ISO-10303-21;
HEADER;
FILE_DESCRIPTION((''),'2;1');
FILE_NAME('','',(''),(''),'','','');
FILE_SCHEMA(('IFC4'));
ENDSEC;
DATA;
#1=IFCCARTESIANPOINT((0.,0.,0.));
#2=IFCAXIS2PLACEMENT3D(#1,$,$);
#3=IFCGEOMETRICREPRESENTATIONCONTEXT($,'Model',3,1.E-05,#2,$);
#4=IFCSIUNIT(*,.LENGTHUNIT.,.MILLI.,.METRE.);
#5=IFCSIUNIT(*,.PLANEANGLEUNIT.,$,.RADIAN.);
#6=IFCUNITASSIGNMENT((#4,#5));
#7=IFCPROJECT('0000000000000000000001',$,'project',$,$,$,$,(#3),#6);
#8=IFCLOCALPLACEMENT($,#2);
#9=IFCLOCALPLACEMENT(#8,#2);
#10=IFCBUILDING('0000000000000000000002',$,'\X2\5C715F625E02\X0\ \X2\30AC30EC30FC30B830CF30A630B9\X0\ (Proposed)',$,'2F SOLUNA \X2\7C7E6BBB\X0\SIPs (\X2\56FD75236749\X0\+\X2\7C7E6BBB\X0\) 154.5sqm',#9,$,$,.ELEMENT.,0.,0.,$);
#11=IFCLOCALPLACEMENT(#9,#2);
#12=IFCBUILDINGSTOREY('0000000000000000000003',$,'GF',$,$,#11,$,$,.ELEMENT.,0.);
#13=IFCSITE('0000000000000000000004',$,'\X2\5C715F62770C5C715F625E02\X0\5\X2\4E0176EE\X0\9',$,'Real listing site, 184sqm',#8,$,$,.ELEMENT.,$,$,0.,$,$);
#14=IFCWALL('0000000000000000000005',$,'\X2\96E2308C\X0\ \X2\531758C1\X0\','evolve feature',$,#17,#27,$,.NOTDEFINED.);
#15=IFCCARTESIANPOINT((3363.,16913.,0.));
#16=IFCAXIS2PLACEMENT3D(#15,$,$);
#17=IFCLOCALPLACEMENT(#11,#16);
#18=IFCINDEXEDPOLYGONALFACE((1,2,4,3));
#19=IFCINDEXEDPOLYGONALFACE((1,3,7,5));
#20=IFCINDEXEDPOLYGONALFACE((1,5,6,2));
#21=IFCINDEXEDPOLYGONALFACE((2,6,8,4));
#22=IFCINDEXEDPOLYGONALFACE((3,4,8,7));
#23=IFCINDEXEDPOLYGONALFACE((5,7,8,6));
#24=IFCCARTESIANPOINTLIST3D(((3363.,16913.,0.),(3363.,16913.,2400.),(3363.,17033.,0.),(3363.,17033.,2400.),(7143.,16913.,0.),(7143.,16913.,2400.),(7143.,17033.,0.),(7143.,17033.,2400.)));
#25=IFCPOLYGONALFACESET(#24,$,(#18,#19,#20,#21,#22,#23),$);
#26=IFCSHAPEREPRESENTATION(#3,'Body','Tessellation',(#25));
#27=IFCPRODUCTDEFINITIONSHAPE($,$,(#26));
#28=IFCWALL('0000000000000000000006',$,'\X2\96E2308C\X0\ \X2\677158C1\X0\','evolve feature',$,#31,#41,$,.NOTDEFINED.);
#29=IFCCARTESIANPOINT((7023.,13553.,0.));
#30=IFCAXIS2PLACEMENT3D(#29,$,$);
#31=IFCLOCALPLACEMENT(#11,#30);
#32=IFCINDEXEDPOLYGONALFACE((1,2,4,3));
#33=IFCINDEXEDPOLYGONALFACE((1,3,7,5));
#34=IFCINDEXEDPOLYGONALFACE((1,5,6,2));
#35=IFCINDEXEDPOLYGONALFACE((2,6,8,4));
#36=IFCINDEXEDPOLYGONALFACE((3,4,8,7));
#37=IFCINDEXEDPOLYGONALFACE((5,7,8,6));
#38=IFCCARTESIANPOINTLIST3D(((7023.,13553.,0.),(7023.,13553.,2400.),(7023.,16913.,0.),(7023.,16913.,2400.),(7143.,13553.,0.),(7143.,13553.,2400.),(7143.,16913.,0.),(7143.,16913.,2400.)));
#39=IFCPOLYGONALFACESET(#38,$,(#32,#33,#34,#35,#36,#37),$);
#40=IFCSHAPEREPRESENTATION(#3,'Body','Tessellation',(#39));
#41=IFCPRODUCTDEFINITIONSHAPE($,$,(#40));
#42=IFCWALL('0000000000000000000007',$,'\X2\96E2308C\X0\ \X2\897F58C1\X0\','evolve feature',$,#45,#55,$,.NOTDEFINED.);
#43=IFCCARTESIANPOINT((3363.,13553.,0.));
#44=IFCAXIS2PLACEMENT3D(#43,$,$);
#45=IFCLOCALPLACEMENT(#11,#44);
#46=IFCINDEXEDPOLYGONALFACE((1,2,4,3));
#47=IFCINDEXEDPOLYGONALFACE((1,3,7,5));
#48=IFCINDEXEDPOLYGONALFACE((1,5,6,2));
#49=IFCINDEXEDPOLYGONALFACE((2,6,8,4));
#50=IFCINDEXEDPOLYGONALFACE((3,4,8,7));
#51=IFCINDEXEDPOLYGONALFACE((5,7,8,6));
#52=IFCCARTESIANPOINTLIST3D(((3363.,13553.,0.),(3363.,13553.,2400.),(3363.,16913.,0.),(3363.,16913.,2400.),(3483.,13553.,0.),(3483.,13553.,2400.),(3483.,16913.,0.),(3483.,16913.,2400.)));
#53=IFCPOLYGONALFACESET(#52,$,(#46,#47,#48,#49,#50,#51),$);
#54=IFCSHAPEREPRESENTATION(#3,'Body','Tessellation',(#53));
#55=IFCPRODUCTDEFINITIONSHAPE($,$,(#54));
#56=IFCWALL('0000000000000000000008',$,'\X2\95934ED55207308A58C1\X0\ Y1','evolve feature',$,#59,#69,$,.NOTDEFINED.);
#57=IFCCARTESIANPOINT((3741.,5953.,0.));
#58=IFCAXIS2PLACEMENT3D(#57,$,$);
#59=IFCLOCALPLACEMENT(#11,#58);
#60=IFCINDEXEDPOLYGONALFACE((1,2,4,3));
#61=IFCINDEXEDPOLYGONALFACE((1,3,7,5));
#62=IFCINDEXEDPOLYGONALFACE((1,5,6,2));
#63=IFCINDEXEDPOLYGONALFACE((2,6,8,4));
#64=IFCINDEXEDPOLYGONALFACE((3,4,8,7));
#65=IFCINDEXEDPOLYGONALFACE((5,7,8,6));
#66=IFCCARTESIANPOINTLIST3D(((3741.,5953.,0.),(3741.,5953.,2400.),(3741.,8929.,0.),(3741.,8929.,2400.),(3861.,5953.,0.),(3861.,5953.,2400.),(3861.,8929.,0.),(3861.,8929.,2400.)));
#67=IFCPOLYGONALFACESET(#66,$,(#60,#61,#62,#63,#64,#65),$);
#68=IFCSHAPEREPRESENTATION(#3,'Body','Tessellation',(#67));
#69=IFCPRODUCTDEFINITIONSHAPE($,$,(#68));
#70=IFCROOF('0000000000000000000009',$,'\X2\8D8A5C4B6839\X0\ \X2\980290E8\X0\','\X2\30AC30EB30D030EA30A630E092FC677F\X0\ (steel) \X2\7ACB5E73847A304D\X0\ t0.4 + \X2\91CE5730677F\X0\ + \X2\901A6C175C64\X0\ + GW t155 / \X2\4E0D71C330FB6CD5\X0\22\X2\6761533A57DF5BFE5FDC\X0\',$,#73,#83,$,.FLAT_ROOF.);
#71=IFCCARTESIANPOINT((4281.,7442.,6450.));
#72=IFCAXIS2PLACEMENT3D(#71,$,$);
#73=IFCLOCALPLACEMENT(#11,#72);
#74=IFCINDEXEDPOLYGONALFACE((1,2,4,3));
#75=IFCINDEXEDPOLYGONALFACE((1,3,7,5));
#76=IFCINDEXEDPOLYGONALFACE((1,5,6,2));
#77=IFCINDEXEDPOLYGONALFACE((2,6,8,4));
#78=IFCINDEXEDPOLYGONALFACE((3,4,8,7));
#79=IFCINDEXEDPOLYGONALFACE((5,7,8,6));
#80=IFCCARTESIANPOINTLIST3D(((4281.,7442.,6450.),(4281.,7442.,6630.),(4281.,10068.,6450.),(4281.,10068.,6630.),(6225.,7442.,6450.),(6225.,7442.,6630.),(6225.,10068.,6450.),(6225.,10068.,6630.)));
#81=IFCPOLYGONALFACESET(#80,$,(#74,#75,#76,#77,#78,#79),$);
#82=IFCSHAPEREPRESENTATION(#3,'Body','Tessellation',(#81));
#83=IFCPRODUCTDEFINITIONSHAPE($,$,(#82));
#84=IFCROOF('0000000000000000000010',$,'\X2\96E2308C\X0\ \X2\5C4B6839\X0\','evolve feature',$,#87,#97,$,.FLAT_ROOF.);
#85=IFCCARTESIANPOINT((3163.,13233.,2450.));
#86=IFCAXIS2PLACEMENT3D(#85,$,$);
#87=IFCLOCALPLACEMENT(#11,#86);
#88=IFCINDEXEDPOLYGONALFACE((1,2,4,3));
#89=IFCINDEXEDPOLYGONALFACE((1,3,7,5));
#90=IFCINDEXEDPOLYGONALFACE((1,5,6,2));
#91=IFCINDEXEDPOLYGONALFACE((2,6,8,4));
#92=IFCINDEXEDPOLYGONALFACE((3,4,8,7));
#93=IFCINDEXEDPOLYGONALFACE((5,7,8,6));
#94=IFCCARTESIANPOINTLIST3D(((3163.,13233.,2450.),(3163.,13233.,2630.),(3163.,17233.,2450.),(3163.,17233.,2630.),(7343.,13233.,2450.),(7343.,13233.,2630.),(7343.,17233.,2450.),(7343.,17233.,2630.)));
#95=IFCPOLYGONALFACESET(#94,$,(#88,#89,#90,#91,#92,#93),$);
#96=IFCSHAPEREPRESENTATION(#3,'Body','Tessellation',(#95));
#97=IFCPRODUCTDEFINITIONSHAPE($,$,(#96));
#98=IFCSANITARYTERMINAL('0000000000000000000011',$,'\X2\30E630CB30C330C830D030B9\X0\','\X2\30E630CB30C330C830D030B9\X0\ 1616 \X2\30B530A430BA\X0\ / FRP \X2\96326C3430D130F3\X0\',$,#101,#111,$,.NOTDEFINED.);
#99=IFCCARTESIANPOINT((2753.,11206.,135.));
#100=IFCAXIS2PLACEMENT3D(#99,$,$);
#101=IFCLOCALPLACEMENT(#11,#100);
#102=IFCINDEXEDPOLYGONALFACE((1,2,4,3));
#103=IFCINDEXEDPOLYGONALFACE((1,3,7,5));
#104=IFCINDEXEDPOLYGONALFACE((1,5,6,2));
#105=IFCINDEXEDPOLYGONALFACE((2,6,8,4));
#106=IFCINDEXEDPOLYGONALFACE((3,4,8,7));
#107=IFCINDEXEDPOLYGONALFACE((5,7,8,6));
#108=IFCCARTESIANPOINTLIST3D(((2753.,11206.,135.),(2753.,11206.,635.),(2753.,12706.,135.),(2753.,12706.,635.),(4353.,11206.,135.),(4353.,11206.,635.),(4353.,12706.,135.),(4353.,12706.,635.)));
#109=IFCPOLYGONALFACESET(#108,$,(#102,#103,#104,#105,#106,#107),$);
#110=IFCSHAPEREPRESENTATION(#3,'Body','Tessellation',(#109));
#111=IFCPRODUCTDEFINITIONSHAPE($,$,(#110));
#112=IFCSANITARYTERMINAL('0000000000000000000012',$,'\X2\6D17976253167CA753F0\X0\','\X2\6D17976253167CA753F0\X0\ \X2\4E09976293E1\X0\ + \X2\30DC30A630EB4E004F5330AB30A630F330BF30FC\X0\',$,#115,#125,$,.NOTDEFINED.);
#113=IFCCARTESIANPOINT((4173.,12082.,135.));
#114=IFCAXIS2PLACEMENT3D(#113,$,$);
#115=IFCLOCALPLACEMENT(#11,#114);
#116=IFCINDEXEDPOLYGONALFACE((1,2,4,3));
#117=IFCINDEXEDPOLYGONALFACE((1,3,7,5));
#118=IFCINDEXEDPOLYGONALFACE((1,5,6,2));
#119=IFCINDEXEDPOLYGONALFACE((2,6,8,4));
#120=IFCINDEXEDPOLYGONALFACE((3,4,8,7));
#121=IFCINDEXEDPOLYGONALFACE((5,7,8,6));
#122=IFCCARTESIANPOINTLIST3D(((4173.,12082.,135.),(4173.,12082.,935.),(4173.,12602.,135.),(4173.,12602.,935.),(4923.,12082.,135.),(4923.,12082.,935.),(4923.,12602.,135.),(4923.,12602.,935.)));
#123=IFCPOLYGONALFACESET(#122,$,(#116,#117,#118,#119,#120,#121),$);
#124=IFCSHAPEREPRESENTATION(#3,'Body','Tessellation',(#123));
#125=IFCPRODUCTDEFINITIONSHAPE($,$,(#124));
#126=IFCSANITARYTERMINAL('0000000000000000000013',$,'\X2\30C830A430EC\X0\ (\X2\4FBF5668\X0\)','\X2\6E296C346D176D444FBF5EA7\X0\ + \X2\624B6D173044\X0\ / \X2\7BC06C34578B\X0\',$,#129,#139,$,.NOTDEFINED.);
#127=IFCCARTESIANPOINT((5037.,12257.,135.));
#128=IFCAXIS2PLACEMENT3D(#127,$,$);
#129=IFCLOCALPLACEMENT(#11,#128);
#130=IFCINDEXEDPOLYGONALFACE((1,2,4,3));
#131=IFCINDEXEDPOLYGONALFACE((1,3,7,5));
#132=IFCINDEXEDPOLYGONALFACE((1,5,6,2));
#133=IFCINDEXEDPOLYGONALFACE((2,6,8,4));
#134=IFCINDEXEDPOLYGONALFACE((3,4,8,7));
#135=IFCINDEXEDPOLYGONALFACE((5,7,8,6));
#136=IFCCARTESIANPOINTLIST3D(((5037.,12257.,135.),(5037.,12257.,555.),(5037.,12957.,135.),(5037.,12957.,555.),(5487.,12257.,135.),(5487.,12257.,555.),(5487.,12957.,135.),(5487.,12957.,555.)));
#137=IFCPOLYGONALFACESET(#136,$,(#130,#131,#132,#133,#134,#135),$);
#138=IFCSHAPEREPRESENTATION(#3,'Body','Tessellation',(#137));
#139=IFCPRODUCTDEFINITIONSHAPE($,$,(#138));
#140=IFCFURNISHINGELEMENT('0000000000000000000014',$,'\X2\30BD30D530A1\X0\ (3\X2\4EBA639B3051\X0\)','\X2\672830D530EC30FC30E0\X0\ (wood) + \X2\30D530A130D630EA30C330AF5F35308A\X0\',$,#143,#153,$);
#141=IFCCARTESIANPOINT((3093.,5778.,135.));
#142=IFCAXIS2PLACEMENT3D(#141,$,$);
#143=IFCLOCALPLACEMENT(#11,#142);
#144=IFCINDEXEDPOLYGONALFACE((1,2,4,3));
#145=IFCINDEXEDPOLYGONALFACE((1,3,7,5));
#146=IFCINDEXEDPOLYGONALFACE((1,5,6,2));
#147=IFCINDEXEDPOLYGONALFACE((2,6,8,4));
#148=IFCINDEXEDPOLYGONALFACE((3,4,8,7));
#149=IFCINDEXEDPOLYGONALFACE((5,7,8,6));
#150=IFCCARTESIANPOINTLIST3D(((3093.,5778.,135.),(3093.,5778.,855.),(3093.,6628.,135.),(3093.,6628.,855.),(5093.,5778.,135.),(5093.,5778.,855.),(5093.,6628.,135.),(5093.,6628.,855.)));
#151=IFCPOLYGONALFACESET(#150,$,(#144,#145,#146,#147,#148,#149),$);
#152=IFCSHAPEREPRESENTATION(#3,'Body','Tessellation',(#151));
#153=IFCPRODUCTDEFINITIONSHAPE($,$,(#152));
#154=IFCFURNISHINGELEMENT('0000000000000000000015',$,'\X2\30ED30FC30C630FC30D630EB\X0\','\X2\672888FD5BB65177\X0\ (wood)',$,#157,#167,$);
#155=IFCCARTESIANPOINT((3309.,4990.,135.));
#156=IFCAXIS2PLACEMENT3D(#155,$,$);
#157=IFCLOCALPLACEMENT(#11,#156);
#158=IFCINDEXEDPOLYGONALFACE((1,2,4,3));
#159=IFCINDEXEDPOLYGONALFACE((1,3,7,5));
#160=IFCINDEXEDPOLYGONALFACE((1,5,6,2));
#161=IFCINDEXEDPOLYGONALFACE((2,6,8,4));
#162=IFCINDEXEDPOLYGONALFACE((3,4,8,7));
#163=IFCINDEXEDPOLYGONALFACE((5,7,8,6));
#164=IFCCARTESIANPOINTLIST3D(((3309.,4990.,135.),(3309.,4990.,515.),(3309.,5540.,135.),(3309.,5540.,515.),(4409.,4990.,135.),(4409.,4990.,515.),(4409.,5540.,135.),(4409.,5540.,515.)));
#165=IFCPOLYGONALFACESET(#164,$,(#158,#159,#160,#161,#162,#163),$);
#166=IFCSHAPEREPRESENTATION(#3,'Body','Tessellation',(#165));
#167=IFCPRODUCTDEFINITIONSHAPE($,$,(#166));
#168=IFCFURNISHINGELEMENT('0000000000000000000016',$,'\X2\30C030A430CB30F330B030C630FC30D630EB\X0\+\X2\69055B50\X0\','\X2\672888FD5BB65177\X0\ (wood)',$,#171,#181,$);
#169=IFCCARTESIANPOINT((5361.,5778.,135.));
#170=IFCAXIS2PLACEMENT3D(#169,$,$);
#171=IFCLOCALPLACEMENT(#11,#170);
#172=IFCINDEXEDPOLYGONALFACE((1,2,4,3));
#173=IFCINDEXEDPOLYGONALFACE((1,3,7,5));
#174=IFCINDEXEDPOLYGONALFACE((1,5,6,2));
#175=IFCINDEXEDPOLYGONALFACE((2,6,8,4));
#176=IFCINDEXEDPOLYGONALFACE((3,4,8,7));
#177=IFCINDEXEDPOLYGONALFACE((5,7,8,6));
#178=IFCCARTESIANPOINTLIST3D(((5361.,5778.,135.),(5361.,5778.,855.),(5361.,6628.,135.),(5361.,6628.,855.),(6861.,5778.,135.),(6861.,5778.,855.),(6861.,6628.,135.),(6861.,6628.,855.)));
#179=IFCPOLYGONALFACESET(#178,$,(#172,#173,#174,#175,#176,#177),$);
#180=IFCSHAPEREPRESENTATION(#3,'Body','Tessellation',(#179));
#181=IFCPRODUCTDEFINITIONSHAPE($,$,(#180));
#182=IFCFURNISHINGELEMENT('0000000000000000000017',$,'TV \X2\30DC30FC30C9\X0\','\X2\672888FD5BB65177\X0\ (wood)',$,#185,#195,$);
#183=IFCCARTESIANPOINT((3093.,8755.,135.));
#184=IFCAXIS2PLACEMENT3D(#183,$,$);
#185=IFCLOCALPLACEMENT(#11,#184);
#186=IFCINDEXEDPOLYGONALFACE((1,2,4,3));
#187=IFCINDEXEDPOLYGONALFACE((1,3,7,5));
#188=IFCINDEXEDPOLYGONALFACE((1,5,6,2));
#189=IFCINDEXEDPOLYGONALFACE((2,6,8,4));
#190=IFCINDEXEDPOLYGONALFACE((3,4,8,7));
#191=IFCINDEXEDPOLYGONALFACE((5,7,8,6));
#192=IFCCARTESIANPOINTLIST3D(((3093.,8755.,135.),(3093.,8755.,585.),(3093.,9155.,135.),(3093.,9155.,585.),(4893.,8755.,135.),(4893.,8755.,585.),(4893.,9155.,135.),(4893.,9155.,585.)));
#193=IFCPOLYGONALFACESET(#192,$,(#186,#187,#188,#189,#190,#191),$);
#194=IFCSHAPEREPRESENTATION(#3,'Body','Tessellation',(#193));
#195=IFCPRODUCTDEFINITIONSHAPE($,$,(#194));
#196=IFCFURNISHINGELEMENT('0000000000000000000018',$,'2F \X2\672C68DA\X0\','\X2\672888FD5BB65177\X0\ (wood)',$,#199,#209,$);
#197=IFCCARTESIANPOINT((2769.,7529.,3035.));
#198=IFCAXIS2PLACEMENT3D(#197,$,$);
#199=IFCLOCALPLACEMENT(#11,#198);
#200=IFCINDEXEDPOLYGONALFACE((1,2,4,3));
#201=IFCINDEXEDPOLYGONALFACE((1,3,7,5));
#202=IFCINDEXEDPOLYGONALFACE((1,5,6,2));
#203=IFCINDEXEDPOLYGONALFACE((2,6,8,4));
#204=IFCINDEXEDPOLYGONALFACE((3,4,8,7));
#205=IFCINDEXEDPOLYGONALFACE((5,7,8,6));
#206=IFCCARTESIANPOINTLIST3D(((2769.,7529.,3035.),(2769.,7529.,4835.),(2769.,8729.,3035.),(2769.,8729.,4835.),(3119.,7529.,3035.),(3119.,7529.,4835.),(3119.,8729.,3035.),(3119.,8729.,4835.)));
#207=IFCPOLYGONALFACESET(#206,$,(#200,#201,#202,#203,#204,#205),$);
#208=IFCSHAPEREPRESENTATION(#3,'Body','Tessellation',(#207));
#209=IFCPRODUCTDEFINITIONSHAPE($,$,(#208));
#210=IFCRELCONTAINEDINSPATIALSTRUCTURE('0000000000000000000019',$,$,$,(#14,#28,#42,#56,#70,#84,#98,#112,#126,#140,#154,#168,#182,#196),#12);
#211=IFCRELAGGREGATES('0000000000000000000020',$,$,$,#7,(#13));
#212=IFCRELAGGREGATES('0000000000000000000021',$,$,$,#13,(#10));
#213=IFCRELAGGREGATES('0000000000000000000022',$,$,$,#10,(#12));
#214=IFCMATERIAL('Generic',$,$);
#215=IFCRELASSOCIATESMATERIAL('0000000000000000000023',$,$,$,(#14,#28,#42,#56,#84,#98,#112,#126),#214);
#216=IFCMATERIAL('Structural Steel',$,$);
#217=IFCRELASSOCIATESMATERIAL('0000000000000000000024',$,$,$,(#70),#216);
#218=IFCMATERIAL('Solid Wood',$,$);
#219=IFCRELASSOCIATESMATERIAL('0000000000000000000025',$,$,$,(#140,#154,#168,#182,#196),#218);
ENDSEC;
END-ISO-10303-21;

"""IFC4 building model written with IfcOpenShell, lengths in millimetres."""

from ifc_helpers import new_model, si_unit, frame, frame_2d, origin, place, context, project, spatial, rectangle, extrude, material, element, save


model = new_model("IFC4")

# Units and contexts
model_context = context("Model", 3, precision=1e-05, world=origin())
ifc_project = project(units=[si_unit("LENGTHUNIT", "METRE", prefix="MILLI"), si_unit("PLANEANGLEUNIT", "RADIAN")], contexts=[model_context])

# Site, building, storey
site_placement = place(None, origin())
site = spatial("IfcSite", under=ifc_project, at=site_placement, Name="山形県山形市5丁目9", ObjectType="Real listing site, 184sqm", CompositionType="ELEMENT", RefElevation=0.0)
building_placement = place(site_placement, origin())
building = spatial("IfcBuilding", under=site, at=building_placement, Name="山形市 ガレージハウス (Proposed)", ObjectType="2F SOLUNA 籾殻SIPs (国産杉+籾殻) 154.5sqm", CompositionType="ELEMENT", ElevationOfRefHeight=0.0, ElevationOfTerrain=0.0)
storey_placement = place(building_placement, origin())
storey = spatial("IfcBuildingStorey", under=building, at=storey_placement, Name="GF", CompositionType="ELEMENT", Elevation=0.0)

# Shared definitions
ifc_material_1 = material(Name="Generic")

# Shared definitions
ifc_material_2 = material(Name="Solid Wood")

# Walls
wall_1_placement = place(storey_placement, frame((3363.0, 16913.0, 0.0)))
element("IfcWall", 1, at=wall_1_placement, inside=storey, material=ifc_material_1, Name="離れ 北壁", Description="evolve feature", PredefinedType="NOTDEFINED", context=model_context, shape_type="SweptSolid", body=[
    extrude(rectangle(XDim=3780.0, YDim=120.0, at=frame_2d((1890.0, 60.0))), frame((3363.0, 16913.0, 0.0)), (0.0, 0.0, 1.0), 2400.0),
])
wall_2_placement = place(storey_placement, frame((7023.0, 13553.0, 0.0)))
element("IfcWall", 2, at=wall_2_placement, inside=storey, material=ifc_material_1, Name="離れ 東壁", Description="evolve feature", PredefinedType="NOTDEFINED", context=model_context, shape_type="SweptSolid", body=[
    extrude(rectangle(XDim=120.0, YDim=3360.0, at=frame_2d((60.0, 1680.0))), frame((7023.0, 13553.0, 0.0)), (0.0, 0.0, 1.0), 2400.0),
])
wall_3_placement = place(storey_placement, frame((3363.0, 13553.0, 0.0)))
element("IfcWall", 3, at=wall_3_placement, inside=storey, material=ifc_material_1, Name="離れ 西壁", Description="evolve feature", PredefinedType="NOTDEFINED", context=model_context, shape_type="SweptSolid", body=[
    extrude(rectangle(XDim=120.0, YDim=3360.0, at=frame_2d((60.0, 1680.0))), frame((3363.0, 13553.0, 0.0)), (0.0, 0.0, 1.0), 2400.0),
])
wall_4_placement = place(storey_placement, frame((3741.0, 5953.0, 0.0)))
element("IfcWall", 4, at=wall_4_placement, inside=storey, material=ifc_material_1, Name="間仕切り壁 Y1", Description="evolve feature", PredefinedType="NOTDEFINED", context=model_context, shape_type="SweptSolid", body=[
    extrude(rectangle(XDim=120.0, YDim=2976.0, at=frame_2d((60.0, 1488.0))), frame((3741.0, 5953.0, 0.0)), (0.0, 0.0, 1.0), 2400.0),
])

# Roofs
ifc_material_3 = material(Name="Structural Steel")
roof_1_placement = place(storey_placement, frame((4281.0, 7442.0, 6450.0)))
element("IfcRoof", 5, at=roof_1_placement, inside=storey, material=ifc_material_3, Name="越屋根 頂部", Description="ガルバリウム鋼板 (steel) 立平葺き t0.4 + 野地板 + 通気層 + GW t155 / 不燃・法22条区域対応", PredefinedType="FLAT_ROOF", context=model_context, shape_type="SweptSolid", body=[
    extrude(rectangle(XDim=1944.0, YDim=2626.0, at=frame_2d((972.0, 1313.0))), frame((4281.0, 7442.0, 6450.0)), (0.0, 0.0, 1.0), 180.0),
])
roof_2_placement = place(storey_placement, frame((3163.0, 13233.0, 2450.0)))
element("IfcRoof", 6, at=roof_2_placement, inside=storey, material=ifc_material_1, Name="離れ 屋根", Description="evolve feature", PredefinedType="FLAT_ROOF", context=model_context, shape_type="SweptSolid", body=[
    extrude(rectangle(XDim=4180.0, YDim=4000.0, at=frame_2d((2090.0, 2000.0))), frame((3163.0, 13233.0, 2450.0)), (0.0, 0.0, 1.0), 180.0),
])

# Sanitary terminals
sanitary_terminal_1_placement = place(storey_placement, frame((2753.0, 11206.0, 135.0)))
element("IfcSanitaryTerminal", 7, at=sanitary_terminal_1_placement, inside=storey, material=ifc_material_1, Name="ユニットバス", Description="ユニットバス 1616 サイズ / FRP 防水パン", PredefinedType="NOTDEFINED", context=model_context, shape_type="SweptSolid", body=[
    extrude(rectangle(XDim=1600.0, YDim=1500.0, at=frame_2d((800.0, 750.0))), frame((2753.0, 11206.0, 135.0)), (0.0, 0.0, 1.0), 500.0),
])
sanitary_terminal_2_placement = place(storey_placement, frame((4173.0, 12082.0, 135.0)))
element("IfcSanitaryTerminal", 8, at=sanitary_terminal_2_placement, inside=storey, material=ifc_material_1, Name="洗面化粧台", Description="洗面化粧台 三面鏡 + ボウル一体カウンター", PredefinedType="NOTDEFINED", context=model_context, shape_type="SweptSolid", body=[
    extrude(rectangle(XDim=750.0, YDim=520.0, at=frame_2d((375.0, 260.0))), frame((4173.0, 12082.0, 135.0)), (0.0, 0.0, 1.0), 800.0),
])
sanitary_terminal_3_placement = place(storey_placement, frame((5037.0, 12257.0, 135.0)))
element("IfcSanitaryTerminal", 9, at=sanitary_terminal_3_placement, inside=storey, material=ifc_material_1, Name="トイレ (便器)", Description="温水洗浄便座 + 手洗い / 節水型", PredefinedType="NOTDEFINED", context=model_context, shape_type="SweptSolid", body=[
    extrude(rectangle(XDim=450.0, YDim=700.0, at=frame_2d((225.0, 350.0))), frame((5037.0, 12257.0, 135.0)), (0.0, 0.0, 1.0), 420.0),
])

# Furnishing elements
furnishing_1_placement = place(storey_placement, frame((3093.0, 5778.0, 135.0)))
element("IfcFurnishingElement", 10, at=furnishing_1_placement, inside=storey, material=ifc_material_2, Name="ソファ (3人掛け)", Description="木フレーム (wood) + ファブリック張り", context=model_context, shape_type="SweptSolid", body=[
    extrude(rectangle(XDim=2000.0, YDim=850.0, at=frame_2d((1000.0, 425.0))), frame((3093.0, 5778.0, 135.0)), (0.0, 0.0, 1.0), 720.0),
])
furnishing_2_placement = place(storey_placement, frame((3309.0, 4990.0, 135.0)))
element("IfcFurnishingElement", 11, at=furnishing_2_placement, inside=storey, material=ifc_material_2, Name="ローテーブル", Description="木製家具 (wood)", context=model_context, shape_type="SweptSolid", body=[
    extrude(rectangle(XDim=1100.0, YDim=550.0, at=frame_2d((550.0, 275.0))), frame((3309.0, 4990.0, 135.0)), (0.0, 0.0, 1.0), 380.0),
])
furnishing_3_placement = place(storey_placement, frame((5361.0, 5778.0, 135.0)))
element("IfcFurnishingElement", 12, at=furnishing_3_placement, inside=storey, material=ifc_material_2, Name="ダイニングテーブル+椅子", Description="木製家具 (wood)", context=model_context, shape_type="SweptSolid", body=[
    extrude(rectangle(XDim=1500.0, YDim=850.0, at=frame_2d((750.0, 425.0))), frame((5361.0, 5778.0, 135.0)), (0.0, 0.0, 1.0), 720.0),
])
furnishing_4_placement = place(storey_placement, frame((3093.0, 8755.0, 135.0)))
element("IfcFurnishingElement", 13, at=furnishing_4_placement, inside=storey, material=ifc_material_2, Name="TV ボード", Description="木製家具 (wood)", context=model_context, shape_type="SweptSolid", body=[
    extrude(rectangle(XDim=1800.0, YDim=400.0, at=frame_2d((900.0, 200.0))), frame((3093.0, 8755.0, 135.0)), (0.0, 0.0, 1.0), 450.0),
])
furnishing_5_placement = place(storey_placement, frame((2769.0, 7529.0, 3035.0)))
element("IfcFurnishingElement", 14, at=furnishing_5_placement, inside=storey, material=ifc_material_2, Name="2F 本棚", Description="木製家具 (wood)", context=model_context, shape_type="SweptSolid", body=[
    extrude(rectangle(XDim=350.0, YDim=1200.0, at=frame_2d((175.0, 600.0))), frame((2769.0, 7529.0, 3035.0)), (0.0, 0.0, 1.0), 1800.0),
])

save(model, "model.ifc")
